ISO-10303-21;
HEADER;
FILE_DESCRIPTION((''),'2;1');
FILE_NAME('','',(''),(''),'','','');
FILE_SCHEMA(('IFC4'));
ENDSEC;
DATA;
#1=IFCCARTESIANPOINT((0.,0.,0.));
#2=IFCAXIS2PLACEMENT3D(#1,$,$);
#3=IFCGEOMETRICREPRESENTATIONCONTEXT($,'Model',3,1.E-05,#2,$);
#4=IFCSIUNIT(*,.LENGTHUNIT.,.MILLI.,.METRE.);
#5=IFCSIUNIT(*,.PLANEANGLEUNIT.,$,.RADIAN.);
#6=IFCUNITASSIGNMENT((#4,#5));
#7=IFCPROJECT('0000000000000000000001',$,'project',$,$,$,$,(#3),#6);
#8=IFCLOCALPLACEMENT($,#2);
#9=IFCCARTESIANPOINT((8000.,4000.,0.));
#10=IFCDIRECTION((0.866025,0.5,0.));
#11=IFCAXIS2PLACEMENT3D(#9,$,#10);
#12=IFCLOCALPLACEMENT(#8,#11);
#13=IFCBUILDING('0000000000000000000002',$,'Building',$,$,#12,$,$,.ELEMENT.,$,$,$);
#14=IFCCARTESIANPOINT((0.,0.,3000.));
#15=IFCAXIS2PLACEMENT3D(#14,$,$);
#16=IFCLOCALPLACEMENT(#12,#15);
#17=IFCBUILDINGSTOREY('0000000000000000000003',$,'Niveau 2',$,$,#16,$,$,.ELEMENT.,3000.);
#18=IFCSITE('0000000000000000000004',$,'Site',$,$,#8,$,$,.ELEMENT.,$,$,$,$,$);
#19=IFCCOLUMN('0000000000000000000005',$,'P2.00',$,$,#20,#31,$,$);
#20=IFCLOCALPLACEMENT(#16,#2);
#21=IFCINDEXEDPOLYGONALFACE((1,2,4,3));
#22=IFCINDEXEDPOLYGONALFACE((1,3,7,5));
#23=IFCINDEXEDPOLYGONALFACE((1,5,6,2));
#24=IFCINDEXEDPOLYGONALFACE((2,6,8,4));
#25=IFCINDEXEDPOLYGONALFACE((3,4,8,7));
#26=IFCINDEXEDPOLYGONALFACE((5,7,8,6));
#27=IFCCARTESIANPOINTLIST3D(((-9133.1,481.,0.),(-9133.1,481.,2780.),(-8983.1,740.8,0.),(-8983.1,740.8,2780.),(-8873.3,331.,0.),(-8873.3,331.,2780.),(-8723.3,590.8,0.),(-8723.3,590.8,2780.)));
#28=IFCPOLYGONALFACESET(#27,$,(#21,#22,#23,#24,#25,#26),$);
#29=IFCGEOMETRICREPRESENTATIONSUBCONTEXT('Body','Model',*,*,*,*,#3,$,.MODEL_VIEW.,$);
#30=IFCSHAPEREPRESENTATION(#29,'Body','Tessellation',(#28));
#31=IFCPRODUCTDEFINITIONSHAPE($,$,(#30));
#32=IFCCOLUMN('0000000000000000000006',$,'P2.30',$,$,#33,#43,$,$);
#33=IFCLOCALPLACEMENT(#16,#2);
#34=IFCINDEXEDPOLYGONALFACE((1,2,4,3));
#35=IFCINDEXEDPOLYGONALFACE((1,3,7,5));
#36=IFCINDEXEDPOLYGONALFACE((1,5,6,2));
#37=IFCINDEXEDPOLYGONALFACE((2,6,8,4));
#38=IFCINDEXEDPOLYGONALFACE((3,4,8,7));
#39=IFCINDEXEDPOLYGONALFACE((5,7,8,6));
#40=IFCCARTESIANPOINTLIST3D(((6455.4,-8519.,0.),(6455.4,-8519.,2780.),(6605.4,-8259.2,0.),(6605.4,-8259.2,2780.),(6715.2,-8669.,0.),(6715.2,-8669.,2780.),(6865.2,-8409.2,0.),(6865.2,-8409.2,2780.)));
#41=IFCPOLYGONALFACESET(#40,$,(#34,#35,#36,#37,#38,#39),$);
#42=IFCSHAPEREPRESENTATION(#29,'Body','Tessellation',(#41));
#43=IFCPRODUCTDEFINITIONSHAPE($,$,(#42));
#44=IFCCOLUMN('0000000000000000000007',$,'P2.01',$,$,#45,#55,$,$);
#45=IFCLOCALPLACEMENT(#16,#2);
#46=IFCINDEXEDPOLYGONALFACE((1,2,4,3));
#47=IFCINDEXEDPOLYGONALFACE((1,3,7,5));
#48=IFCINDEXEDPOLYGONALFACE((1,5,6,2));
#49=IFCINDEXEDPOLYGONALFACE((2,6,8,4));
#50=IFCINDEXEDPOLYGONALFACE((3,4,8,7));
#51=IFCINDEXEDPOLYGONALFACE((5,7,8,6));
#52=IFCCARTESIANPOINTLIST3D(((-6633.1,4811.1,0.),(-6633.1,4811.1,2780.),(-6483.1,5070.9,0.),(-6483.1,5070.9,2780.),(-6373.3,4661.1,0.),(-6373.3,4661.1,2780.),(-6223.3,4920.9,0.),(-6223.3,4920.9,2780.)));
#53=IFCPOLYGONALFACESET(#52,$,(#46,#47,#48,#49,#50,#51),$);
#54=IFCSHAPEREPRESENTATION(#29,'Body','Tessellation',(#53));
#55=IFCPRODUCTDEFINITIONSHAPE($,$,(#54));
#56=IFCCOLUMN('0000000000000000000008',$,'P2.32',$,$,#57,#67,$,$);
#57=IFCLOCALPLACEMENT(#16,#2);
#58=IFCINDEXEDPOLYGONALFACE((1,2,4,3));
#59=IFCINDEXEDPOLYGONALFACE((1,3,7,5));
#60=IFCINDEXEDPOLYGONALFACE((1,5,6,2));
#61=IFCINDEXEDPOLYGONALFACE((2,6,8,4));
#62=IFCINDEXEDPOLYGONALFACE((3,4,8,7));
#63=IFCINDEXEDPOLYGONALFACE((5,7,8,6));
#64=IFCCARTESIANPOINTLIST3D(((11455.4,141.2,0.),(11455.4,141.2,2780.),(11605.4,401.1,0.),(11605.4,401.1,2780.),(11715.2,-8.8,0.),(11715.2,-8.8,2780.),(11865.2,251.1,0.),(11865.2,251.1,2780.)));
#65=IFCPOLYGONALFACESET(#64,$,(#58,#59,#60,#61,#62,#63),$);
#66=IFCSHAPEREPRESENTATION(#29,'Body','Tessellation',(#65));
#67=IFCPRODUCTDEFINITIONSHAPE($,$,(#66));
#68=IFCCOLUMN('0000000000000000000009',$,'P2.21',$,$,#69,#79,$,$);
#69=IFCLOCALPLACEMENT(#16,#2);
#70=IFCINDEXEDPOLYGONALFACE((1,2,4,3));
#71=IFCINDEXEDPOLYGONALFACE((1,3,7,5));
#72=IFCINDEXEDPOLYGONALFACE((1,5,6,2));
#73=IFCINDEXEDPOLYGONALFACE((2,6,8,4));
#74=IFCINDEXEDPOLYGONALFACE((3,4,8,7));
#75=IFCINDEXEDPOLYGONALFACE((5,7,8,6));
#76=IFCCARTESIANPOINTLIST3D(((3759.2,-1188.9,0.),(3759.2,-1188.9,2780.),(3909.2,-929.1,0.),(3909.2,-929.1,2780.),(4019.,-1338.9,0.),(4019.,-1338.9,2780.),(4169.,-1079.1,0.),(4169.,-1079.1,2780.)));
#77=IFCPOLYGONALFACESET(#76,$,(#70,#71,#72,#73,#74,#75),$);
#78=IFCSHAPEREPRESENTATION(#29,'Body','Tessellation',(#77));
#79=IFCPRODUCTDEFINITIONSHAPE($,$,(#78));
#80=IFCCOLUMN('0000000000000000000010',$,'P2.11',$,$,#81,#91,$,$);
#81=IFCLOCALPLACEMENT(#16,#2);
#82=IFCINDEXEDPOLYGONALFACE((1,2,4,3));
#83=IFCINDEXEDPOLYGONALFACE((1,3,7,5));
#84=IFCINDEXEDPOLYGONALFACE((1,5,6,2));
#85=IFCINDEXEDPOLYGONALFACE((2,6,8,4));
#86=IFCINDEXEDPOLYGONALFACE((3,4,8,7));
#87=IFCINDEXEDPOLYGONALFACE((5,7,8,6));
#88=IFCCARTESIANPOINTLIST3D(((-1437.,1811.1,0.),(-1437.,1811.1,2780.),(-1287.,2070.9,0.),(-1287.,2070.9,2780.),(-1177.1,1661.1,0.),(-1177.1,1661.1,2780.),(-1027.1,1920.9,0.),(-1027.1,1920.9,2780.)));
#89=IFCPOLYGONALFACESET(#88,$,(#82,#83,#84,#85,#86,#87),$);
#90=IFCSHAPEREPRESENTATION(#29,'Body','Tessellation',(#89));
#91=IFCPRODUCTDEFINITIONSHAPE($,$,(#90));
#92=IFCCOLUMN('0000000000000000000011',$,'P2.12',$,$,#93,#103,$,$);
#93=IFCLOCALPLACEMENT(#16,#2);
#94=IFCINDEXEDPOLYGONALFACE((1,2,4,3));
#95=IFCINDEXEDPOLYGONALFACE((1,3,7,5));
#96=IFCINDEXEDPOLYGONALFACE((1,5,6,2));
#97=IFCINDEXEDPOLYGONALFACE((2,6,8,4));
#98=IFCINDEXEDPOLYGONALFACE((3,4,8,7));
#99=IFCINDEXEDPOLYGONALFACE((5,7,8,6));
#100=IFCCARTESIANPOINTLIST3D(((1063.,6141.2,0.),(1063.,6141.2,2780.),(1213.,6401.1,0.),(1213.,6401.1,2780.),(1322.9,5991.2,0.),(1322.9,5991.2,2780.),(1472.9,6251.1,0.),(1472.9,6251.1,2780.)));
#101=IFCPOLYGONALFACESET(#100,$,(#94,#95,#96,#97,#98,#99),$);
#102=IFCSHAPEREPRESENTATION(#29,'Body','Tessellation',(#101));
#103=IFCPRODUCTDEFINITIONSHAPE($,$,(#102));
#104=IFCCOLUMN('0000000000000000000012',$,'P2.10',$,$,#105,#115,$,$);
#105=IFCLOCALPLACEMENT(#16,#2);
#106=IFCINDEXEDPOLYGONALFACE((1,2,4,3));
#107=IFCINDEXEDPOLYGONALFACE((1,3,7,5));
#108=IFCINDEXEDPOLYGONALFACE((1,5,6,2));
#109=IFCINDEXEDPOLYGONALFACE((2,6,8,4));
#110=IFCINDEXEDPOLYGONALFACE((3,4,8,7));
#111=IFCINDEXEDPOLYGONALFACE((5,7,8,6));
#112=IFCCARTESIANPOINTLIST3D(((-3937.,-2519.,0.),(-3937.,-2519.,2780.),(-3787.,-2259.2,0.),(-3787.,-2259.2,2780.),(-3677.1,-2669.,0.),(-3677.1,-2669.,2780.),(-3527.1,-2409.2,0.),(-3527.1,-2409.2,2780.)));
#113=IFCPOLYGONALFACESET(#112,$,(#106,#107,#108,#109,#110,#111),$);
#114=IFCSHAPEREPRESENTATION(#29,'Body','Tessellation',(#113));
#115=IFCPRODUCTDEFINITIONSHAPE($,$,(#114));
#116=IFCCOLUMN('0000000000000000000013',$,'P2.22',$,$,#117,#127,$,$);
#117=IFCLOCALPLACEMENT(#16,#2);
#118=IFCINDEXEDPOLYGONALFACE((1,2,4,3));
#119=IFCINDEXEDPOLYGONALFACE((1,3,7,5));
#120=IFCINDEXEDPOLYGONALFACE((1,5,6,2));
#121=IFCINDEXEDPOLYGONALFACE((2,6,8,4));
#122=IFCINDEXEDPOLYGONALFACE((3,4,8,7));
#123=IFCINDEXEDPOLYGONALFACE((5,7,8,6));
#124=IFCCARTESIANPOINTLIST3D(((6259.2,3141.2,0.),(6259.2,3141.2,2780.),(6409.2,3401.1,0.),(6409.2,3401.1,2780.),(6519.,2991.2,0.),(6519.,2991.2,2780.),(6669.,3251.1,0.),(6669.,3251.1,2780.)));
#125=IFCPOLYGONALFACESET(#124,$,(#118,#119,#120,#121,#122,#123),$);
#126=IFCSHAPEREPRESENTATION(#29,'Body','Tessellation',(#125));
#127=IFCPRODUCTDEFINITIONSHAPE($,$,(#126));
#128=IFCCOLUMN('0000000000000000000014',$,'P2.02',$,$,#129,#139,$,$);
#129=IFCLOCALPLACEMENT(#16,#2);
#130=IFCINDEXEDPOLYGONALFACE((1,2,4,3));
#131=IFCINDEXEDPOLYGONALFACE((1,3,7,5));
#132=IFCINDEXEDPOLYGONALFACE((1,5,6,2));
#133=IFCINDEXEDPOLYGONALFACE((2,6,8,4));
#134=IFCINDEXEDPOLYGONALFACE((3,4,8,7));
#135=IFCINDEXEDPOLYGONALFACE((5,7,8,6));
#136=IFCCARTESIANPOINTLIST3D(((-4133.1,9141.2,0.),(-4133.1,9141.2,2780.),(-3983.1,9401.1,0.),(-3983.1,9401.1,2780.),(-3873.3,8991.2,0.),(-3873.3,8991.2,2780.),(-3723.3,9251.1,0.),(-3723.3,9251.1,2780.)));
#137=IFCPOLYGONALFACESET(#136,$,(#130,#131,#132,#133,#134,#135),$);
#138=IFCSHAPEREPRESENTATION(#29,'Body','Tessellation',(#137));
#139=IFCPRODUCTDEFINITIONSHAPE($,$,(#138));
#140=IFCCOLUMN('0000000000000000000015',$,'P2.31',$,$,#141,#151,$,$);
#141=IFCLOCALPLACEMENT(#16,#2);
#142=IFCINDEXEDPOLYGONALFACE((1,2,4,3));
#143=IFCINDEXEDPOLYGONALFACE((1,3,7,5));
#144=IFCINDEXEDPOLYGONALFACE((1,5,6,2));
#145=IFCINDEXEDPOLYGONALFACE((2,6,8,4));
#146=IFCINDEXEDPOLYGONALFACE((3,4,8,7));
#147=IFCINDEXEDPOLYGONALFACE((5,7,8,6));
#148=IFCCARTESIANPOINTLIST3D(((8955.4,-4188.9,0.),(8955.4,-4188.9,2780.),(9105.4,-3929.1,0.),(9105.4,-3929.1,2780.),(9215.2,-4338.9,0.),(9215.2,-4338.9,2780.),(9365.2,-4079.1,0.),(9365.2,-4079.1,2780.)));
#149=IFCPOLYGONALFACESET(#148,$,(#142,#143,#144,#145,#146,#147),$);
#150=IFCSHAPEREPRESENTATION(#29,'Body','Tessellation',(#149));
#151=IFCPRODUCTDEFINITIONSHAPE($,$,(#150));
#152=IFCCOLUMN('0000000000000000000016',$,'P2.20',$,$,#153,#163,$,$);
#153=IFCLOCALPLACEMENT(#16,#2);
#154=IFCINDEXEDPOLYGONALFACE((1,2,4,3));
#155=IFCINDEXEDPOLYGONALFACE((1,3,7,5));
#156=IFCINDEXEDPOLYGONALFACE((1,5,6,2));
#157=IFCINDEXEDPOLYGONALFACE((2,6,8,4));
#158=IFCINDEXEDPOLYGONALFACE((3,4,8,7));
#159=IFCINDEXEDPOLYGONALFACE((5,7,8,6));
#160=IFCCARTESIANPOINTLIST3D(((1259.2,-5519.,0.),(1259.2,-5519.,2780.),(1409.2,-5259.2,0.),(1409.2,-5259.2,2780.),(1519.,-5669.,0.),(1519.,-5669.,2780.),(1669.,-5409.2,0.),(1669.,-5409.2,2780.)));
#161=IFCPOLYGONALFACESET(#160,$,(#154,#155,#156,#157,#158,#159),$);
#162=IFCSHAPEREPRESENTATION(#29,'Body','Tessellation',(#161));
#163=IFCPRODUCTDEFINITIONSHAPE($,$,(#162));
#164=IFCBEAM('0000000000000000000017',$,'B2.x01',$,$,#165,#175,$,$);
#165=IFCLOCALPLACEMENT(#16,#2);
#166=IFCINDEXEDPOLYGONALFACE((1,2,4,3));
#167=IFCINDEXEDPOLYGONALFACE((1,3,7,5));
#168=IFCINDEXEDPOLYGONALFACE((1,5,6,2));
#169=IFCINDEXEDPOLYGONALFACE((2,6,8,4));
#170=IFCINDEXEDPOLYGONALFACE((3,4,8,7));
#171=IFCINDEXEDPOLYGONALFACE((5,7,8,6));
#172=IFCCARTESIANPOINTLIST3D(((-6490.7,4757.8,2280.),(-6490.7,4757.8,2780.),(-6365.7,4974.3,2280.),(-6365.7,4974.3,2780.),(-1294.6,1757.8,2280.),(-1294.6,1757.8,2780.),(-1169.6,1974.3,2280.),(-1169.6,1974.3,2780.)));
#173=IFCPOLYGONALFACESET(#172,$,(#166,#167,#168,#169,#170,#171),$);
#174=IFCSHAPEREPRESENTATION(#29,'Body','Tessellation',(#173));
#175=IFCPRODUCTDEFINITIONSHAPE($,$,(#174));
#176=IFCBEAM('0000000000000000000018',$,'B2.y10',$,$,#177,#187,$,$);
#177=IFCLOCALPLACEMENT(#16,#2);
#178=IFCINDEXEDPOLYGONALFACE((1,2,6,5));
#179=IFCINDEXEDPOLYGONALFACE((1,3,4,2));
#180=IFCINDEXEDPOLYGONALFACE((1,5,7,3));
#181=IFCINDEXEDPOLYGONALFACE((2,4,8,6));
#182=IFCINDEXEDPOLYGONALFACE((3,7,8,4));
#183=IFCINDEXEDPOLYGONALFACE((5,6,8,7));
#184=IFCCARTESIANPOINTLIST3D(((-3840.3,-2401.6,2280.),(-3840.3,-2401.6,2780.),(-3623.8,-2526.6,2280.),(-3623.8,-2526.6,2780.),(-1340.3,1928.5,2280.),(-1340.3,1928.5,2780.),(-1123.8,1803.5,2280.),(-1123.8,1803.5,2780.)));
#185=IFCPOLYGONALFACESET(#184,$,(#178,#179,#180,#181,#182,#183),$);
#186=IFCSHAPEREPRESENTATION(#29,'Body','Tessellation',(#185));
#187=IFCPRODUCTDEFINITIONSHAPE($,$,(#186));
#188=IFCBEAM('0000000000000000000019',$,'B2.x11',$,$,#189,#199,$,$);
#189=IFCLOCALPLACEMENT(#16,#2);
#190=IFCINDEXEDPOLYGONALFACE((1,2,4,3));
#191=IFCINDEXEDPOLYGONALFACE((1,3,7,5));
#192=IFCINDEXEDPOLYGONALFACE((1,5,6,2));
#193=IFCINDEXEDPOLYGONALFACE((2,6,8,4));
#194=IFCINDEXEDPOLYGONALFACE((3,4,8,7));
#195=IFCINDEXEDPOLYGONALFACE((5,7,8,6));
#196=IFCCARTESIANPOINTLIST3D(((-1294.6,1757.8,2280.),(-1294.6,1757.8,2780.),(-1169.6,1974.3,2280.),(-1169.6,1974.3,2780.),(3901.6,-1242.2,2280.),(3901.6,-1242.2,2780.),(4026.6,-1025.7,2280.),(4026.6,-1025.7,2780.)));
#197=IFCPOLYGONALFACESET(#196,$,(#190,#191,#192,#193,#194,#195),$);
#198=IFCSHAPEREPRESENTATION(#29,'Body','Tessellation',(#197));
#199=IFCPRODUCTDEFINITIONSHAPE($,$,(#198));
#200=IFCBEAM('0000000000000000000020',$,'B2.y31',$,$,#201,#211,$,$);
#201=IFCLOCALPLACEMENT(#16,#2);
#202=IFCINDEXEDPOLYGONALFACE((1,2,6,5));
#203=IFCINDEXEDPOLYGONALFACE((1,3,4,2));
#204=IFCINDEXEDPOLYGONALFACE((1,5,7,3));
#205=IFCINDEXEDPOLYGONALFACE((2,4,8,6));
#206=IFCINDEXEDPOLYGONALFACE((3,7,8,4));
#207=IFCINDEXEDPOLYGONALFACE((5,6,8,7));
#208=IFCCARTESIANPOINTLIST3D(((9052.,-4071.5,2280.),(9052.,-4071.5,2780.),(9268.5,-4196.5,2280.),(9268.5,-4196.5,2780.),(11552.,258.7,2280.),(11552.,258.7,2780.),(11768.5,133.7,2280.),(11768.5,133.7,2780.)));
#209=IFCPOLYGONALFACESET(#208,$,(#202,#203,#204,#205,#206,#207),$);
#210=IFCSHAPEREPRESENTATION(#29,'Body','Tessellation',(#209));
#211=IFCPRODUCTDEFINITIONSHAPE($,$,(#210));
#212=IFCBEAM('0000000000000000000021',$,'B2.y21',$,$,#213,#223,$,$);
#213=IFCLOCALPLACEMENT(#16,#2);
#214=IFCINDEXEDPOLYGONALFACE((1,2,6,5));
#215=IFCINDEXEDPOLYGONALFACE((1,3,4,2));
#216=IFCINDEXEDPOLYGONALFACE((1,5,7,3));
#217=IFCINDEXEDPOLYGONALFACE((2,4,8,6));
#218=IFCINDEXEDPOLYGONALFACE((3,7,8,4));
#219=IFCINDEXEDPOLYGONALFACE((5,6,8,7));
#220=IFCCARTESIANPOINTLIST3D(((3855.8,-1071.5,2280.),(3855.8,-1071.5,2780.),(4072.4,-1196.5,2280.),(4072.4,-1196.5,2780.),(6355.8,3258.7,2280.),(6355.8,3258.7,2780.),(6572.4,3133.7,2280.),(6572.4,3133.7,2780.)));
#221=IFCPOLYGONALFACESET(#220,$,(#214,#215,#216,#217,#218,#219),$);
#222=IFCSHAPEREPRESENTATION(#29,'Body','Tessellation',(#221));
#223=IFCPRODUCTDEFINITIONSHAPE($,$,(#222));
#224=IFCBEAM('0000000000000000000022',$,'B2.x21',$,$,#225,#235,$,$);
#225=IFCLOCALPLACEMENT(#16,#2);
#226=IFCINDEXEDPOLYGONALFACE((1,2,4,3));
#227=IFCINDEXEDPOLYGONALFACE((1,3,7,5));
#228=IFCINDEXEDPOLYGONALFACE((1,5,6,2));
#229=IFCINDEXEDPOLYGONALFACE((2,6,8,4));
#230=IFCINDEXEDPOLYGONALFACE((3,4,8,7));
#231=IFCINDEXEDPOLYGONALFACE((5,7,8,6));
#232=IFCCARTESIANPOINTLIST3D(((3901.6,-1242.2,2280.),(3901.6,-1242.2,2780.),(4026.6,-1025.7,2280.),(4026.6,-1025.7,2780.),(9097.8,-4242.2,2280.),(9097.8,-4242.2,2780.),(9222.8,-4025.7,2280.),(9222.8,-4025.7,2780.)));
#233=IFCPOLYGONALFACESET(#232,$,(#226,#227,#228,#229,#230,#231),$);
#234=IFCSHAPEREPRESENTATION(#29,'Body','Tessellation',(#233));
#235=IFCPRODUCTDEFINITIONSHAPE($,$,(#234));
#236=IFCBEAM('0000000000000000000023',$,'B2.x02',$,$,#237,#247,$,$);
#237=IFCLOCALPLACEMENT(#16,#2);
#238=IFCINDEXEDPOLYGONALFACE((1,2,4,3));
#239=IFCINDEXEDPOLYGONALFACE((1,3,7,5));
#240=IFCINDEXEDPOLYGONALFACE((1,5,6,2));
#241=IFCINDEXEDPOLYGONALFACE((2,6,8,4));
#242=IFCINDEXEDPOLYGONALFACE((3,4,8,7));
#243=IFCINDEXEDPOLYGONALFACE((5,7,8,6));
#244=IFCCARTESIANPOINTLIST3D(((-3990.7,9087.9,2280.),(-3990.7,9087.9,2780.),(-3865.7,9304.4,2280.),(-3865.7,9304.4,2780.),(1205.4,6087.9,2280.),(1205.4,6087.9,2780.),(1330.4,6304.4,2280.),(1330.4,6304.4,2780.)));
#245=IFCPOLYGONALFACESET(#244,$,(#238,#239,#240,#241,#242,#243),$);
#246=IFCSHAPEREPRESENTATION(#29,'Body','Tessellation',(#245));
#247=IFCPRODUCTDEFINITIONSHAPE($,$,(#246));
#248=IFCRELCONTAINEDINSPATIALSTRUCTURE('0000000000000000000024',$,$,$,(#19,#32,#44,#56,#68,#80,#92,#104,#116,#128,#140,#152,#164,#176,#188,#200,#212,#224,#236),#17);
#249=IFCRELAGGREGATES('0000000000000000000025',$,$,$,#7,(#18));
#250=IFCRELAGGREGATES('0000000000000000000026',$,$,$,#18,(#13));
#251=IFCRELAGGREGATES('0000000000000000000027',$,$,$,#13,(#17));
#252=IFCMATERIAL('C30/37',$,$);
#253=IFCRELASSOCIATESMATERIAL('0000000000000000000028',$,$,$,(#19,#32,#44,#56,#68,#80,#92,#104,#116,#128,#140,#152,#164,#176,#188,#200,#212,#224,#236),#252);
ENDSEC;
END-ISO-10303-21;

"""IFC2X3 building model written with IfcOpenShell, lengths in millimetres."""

from ifc_helpers import new_model, si_unit, frame, origin, origin_2d, place, context, subcontext, project, spatial, rectangle, extrude, material, element, save


model = new_model("IFC2X3")

# Units and contexts
model_context = context("Model", 3, precision=1e-05, world=origin())
body_context = subcontext(model_context, "Body", "Model", "MODEL_VIEW")
ifc_project = project(units=[si_unit("LENGTHUNIT", "METRE", prefix="MILLI"), si_unit("PLANEANGLEUNIT", "RADIAN")], contexts=[model_context])

# Site, building, storey
site_placement = place(None, origin())
site = spatial("IfcSite", under=ifc_project, at=site_placement, Name="Site", CompositionType="ELEMENT")
building_placement = place(site_placement, frame((8000.0, 4000.0, 0.0), x_axis=(0.866025, 0.5, 0.0)))
building = spatial("IfcBuilding", under=site, at=building_placement, Name="Building", CompositionType="ELEMENT")
storey_placement = place(building_placement, frame((0.0, 0.0, 3000.0)))
storey = spatial("IfcBuildingStorey", under=building, at=storey_placement, Name="Niveau 2", CompositionType="ELEMENT", Elevation=3000.0)

# Columns
ifc_material = material(Name="C30/37")
for number, where, z_axis, x_axis, name in (
    (1, (-8928.2, 535.9, 0.0), (0.0, 0.0, 1.0), (0.866025, -0.5, 0.0), "P2.00"),
    (2, (6660.3, -8464.1, 0.0), (0.0, 0.0, 1.0), (0.866025, -0.5, 0.0), "P2.30"),
    (3, (-6428.2, 4866.0, 0.0), (0.0, 0.0, 1.0), (0.866025, -0.5, 0.0), "P2.01"),
    (4, (11660.3, 196.2, 0.0), (0.0, 0.0, 1.0), (0.866025, -0.5, 0.0), "P2.32"),
    (5, (3964.1, -1134.0, 0.0), (0.0, 0.0, 1.0), (0.866025, -0.5, 0.0), "P2.21"),
    (6, (-1232.1, 1866.0, 0.0), (0.0, 0.0, 1.0), (0.866025, -0.5, 0.0), "P2.11"),
    (7, (1267.9, 6196.2, 0.0), (0.0, 0.0, 1.0), (0.866025, -0.5, 0.0), "P2.12"),
    (8, (-3732.1, -2464.1, 0.0), (0.0, 0.0, 1.0), (0.866025, -0.5, 0.0), "P2.10"),
    (9, (6464.1, 3196.2, 0.0), (0.0, 0.0, 1.0), (0.866025, -0.5, 0.0), "P2.22"),
    (10, (-3928.2, 9196.2, 0.0), (0.0, 0.0, 1.0), (0.866025, -0.5, 0.0), "P2.02"),
    (11, (9160.3, -4134.0, 0.0), (0.0, 0.0, 1.0), (0.866025, -0.5, 0.0), "P2.31"),
    (12, (1464.1, -5464.1, 0.0), (0.0, 0.0, 1.0), (0.866025, -0.5, 0.0), "P2.20"),
):
    element("IfcColumn", number, at=place(storey_placement, frame(where, z_axis=z_axis, x_axis=x_axis)), inside=storey, material=ifc_material, Name=name, context=body_context, shape_type="SweptSolid", body=[
        extrude(rectangle(XDim=300.0, YDim=300.0, at=origin_2d()), origin(), (0.0, 0.0, 1.0), 2780.0),
    ])

# Beams
beam_1_placement = place(storey_placement, frame((-6428.2, 4866.0, 2530.0), z_axis=(0.866025, -0.5, 0.0), x_axis=(0.5, 0.866025, 0.0)))
element("IfcBeam", 13, at=beam_1_placement, inside=storey, material=ifc_material, Name="B2.x01", context=body_context, shape_type="SweptSolid", body=[
    extrude(rectangle(XDim=250.0, YDim=500.0, at=origin_2d()), origin(), (0.0, 0.0, 1.0), 6000.0),
])
beam_2_placement = place(storey_placement, frame((-3732.1, -2464.1, 2530.0), z_axis=(0.5, 0.866025, 0.0), x_axis=(-0.866025, 0.5, 0.0)))
element("IfcBeam", 14, at=beam_2_placement, inside=storey, material=ifc_material, Name="B2.y10", context=body_context, shape_type="SweptSolid", body=[
    extrude(rectangle(XDim=250.0, YDim=500.0, at=origin_2d()), origin(), (0.0, 0.0, 1.0), 5000.0),
])
beam_3_placement = place(storey_placement, frame((-1232.1, 1866.0, 2530.0), z_axis=(0.866025, -0.5, 0.0), x_axis=(0.5, 0.866025, 0.0)))
element("IfcBeam", 15, at=beam_3_placement, inside=storey, material=ifc_material, Name="B2.x11", context=body_context, shape_type="SweptSolid", body=[
    extrude(rectangle(XDim=250.0, YDim=500.0, at=origin_2d()), origin(), (0.0, 0.0, 1.0), 6000.0),
])
for number, where, z_axis, x_axis, name in (
    (16, (9160.3, -4134.0, 2530.0), (0.5, 0.866025, 0.0), (-0.866025, 0.5, 0.0), "B2.y31"),
    (17, (3964.1, -1134.0, 2530.0), (0.5, 0.866025, 0.0), (-0.866025, 0.5, 0.0), "B2.y21"),
):
    element("IfcBeam", number, at=place(storey_placement, frame(where, z_axis=z_axis, x_axis=x_axis)), inside=storey, material=ifc_material, Name=name, context=body_context, shape_type="SweptSolid", body=[
        extrude(rectangle(XDim=250.0, YDim=500.0, at=origin_2d()), origin(), (0.0, 0.0, 1.0), 5000.0),
    ])
for number, where, z_axis, x_axis, name in (
    (18, (3964.1, -1134.0, 2530.0), (0.866025, -0.5, 0.0), (0.5, 0.866025, 0.0), "B2.x21"),
    (19, (-3928.2, 9196.2, 2530.0), (0.866025, -0.5, 0.0), (0.5, 0.866025, 0.0), "B2.x02"),
):
    element("IfcBeam", number, at=place(storey_placement, frame(where, z_axis=z_axis, x_axis=x_axis)), inside=storey, material=ifc_material, Name=name, context=body_context, shape_type="SweptSolid", body=[
        extrude(rectangle(XDim=250.0, YDim=500.0, at=origin_2d()), origin(), (0.0, 0.0, 1.0), 6000.0),
    ])

save(model, "model.ifc")
